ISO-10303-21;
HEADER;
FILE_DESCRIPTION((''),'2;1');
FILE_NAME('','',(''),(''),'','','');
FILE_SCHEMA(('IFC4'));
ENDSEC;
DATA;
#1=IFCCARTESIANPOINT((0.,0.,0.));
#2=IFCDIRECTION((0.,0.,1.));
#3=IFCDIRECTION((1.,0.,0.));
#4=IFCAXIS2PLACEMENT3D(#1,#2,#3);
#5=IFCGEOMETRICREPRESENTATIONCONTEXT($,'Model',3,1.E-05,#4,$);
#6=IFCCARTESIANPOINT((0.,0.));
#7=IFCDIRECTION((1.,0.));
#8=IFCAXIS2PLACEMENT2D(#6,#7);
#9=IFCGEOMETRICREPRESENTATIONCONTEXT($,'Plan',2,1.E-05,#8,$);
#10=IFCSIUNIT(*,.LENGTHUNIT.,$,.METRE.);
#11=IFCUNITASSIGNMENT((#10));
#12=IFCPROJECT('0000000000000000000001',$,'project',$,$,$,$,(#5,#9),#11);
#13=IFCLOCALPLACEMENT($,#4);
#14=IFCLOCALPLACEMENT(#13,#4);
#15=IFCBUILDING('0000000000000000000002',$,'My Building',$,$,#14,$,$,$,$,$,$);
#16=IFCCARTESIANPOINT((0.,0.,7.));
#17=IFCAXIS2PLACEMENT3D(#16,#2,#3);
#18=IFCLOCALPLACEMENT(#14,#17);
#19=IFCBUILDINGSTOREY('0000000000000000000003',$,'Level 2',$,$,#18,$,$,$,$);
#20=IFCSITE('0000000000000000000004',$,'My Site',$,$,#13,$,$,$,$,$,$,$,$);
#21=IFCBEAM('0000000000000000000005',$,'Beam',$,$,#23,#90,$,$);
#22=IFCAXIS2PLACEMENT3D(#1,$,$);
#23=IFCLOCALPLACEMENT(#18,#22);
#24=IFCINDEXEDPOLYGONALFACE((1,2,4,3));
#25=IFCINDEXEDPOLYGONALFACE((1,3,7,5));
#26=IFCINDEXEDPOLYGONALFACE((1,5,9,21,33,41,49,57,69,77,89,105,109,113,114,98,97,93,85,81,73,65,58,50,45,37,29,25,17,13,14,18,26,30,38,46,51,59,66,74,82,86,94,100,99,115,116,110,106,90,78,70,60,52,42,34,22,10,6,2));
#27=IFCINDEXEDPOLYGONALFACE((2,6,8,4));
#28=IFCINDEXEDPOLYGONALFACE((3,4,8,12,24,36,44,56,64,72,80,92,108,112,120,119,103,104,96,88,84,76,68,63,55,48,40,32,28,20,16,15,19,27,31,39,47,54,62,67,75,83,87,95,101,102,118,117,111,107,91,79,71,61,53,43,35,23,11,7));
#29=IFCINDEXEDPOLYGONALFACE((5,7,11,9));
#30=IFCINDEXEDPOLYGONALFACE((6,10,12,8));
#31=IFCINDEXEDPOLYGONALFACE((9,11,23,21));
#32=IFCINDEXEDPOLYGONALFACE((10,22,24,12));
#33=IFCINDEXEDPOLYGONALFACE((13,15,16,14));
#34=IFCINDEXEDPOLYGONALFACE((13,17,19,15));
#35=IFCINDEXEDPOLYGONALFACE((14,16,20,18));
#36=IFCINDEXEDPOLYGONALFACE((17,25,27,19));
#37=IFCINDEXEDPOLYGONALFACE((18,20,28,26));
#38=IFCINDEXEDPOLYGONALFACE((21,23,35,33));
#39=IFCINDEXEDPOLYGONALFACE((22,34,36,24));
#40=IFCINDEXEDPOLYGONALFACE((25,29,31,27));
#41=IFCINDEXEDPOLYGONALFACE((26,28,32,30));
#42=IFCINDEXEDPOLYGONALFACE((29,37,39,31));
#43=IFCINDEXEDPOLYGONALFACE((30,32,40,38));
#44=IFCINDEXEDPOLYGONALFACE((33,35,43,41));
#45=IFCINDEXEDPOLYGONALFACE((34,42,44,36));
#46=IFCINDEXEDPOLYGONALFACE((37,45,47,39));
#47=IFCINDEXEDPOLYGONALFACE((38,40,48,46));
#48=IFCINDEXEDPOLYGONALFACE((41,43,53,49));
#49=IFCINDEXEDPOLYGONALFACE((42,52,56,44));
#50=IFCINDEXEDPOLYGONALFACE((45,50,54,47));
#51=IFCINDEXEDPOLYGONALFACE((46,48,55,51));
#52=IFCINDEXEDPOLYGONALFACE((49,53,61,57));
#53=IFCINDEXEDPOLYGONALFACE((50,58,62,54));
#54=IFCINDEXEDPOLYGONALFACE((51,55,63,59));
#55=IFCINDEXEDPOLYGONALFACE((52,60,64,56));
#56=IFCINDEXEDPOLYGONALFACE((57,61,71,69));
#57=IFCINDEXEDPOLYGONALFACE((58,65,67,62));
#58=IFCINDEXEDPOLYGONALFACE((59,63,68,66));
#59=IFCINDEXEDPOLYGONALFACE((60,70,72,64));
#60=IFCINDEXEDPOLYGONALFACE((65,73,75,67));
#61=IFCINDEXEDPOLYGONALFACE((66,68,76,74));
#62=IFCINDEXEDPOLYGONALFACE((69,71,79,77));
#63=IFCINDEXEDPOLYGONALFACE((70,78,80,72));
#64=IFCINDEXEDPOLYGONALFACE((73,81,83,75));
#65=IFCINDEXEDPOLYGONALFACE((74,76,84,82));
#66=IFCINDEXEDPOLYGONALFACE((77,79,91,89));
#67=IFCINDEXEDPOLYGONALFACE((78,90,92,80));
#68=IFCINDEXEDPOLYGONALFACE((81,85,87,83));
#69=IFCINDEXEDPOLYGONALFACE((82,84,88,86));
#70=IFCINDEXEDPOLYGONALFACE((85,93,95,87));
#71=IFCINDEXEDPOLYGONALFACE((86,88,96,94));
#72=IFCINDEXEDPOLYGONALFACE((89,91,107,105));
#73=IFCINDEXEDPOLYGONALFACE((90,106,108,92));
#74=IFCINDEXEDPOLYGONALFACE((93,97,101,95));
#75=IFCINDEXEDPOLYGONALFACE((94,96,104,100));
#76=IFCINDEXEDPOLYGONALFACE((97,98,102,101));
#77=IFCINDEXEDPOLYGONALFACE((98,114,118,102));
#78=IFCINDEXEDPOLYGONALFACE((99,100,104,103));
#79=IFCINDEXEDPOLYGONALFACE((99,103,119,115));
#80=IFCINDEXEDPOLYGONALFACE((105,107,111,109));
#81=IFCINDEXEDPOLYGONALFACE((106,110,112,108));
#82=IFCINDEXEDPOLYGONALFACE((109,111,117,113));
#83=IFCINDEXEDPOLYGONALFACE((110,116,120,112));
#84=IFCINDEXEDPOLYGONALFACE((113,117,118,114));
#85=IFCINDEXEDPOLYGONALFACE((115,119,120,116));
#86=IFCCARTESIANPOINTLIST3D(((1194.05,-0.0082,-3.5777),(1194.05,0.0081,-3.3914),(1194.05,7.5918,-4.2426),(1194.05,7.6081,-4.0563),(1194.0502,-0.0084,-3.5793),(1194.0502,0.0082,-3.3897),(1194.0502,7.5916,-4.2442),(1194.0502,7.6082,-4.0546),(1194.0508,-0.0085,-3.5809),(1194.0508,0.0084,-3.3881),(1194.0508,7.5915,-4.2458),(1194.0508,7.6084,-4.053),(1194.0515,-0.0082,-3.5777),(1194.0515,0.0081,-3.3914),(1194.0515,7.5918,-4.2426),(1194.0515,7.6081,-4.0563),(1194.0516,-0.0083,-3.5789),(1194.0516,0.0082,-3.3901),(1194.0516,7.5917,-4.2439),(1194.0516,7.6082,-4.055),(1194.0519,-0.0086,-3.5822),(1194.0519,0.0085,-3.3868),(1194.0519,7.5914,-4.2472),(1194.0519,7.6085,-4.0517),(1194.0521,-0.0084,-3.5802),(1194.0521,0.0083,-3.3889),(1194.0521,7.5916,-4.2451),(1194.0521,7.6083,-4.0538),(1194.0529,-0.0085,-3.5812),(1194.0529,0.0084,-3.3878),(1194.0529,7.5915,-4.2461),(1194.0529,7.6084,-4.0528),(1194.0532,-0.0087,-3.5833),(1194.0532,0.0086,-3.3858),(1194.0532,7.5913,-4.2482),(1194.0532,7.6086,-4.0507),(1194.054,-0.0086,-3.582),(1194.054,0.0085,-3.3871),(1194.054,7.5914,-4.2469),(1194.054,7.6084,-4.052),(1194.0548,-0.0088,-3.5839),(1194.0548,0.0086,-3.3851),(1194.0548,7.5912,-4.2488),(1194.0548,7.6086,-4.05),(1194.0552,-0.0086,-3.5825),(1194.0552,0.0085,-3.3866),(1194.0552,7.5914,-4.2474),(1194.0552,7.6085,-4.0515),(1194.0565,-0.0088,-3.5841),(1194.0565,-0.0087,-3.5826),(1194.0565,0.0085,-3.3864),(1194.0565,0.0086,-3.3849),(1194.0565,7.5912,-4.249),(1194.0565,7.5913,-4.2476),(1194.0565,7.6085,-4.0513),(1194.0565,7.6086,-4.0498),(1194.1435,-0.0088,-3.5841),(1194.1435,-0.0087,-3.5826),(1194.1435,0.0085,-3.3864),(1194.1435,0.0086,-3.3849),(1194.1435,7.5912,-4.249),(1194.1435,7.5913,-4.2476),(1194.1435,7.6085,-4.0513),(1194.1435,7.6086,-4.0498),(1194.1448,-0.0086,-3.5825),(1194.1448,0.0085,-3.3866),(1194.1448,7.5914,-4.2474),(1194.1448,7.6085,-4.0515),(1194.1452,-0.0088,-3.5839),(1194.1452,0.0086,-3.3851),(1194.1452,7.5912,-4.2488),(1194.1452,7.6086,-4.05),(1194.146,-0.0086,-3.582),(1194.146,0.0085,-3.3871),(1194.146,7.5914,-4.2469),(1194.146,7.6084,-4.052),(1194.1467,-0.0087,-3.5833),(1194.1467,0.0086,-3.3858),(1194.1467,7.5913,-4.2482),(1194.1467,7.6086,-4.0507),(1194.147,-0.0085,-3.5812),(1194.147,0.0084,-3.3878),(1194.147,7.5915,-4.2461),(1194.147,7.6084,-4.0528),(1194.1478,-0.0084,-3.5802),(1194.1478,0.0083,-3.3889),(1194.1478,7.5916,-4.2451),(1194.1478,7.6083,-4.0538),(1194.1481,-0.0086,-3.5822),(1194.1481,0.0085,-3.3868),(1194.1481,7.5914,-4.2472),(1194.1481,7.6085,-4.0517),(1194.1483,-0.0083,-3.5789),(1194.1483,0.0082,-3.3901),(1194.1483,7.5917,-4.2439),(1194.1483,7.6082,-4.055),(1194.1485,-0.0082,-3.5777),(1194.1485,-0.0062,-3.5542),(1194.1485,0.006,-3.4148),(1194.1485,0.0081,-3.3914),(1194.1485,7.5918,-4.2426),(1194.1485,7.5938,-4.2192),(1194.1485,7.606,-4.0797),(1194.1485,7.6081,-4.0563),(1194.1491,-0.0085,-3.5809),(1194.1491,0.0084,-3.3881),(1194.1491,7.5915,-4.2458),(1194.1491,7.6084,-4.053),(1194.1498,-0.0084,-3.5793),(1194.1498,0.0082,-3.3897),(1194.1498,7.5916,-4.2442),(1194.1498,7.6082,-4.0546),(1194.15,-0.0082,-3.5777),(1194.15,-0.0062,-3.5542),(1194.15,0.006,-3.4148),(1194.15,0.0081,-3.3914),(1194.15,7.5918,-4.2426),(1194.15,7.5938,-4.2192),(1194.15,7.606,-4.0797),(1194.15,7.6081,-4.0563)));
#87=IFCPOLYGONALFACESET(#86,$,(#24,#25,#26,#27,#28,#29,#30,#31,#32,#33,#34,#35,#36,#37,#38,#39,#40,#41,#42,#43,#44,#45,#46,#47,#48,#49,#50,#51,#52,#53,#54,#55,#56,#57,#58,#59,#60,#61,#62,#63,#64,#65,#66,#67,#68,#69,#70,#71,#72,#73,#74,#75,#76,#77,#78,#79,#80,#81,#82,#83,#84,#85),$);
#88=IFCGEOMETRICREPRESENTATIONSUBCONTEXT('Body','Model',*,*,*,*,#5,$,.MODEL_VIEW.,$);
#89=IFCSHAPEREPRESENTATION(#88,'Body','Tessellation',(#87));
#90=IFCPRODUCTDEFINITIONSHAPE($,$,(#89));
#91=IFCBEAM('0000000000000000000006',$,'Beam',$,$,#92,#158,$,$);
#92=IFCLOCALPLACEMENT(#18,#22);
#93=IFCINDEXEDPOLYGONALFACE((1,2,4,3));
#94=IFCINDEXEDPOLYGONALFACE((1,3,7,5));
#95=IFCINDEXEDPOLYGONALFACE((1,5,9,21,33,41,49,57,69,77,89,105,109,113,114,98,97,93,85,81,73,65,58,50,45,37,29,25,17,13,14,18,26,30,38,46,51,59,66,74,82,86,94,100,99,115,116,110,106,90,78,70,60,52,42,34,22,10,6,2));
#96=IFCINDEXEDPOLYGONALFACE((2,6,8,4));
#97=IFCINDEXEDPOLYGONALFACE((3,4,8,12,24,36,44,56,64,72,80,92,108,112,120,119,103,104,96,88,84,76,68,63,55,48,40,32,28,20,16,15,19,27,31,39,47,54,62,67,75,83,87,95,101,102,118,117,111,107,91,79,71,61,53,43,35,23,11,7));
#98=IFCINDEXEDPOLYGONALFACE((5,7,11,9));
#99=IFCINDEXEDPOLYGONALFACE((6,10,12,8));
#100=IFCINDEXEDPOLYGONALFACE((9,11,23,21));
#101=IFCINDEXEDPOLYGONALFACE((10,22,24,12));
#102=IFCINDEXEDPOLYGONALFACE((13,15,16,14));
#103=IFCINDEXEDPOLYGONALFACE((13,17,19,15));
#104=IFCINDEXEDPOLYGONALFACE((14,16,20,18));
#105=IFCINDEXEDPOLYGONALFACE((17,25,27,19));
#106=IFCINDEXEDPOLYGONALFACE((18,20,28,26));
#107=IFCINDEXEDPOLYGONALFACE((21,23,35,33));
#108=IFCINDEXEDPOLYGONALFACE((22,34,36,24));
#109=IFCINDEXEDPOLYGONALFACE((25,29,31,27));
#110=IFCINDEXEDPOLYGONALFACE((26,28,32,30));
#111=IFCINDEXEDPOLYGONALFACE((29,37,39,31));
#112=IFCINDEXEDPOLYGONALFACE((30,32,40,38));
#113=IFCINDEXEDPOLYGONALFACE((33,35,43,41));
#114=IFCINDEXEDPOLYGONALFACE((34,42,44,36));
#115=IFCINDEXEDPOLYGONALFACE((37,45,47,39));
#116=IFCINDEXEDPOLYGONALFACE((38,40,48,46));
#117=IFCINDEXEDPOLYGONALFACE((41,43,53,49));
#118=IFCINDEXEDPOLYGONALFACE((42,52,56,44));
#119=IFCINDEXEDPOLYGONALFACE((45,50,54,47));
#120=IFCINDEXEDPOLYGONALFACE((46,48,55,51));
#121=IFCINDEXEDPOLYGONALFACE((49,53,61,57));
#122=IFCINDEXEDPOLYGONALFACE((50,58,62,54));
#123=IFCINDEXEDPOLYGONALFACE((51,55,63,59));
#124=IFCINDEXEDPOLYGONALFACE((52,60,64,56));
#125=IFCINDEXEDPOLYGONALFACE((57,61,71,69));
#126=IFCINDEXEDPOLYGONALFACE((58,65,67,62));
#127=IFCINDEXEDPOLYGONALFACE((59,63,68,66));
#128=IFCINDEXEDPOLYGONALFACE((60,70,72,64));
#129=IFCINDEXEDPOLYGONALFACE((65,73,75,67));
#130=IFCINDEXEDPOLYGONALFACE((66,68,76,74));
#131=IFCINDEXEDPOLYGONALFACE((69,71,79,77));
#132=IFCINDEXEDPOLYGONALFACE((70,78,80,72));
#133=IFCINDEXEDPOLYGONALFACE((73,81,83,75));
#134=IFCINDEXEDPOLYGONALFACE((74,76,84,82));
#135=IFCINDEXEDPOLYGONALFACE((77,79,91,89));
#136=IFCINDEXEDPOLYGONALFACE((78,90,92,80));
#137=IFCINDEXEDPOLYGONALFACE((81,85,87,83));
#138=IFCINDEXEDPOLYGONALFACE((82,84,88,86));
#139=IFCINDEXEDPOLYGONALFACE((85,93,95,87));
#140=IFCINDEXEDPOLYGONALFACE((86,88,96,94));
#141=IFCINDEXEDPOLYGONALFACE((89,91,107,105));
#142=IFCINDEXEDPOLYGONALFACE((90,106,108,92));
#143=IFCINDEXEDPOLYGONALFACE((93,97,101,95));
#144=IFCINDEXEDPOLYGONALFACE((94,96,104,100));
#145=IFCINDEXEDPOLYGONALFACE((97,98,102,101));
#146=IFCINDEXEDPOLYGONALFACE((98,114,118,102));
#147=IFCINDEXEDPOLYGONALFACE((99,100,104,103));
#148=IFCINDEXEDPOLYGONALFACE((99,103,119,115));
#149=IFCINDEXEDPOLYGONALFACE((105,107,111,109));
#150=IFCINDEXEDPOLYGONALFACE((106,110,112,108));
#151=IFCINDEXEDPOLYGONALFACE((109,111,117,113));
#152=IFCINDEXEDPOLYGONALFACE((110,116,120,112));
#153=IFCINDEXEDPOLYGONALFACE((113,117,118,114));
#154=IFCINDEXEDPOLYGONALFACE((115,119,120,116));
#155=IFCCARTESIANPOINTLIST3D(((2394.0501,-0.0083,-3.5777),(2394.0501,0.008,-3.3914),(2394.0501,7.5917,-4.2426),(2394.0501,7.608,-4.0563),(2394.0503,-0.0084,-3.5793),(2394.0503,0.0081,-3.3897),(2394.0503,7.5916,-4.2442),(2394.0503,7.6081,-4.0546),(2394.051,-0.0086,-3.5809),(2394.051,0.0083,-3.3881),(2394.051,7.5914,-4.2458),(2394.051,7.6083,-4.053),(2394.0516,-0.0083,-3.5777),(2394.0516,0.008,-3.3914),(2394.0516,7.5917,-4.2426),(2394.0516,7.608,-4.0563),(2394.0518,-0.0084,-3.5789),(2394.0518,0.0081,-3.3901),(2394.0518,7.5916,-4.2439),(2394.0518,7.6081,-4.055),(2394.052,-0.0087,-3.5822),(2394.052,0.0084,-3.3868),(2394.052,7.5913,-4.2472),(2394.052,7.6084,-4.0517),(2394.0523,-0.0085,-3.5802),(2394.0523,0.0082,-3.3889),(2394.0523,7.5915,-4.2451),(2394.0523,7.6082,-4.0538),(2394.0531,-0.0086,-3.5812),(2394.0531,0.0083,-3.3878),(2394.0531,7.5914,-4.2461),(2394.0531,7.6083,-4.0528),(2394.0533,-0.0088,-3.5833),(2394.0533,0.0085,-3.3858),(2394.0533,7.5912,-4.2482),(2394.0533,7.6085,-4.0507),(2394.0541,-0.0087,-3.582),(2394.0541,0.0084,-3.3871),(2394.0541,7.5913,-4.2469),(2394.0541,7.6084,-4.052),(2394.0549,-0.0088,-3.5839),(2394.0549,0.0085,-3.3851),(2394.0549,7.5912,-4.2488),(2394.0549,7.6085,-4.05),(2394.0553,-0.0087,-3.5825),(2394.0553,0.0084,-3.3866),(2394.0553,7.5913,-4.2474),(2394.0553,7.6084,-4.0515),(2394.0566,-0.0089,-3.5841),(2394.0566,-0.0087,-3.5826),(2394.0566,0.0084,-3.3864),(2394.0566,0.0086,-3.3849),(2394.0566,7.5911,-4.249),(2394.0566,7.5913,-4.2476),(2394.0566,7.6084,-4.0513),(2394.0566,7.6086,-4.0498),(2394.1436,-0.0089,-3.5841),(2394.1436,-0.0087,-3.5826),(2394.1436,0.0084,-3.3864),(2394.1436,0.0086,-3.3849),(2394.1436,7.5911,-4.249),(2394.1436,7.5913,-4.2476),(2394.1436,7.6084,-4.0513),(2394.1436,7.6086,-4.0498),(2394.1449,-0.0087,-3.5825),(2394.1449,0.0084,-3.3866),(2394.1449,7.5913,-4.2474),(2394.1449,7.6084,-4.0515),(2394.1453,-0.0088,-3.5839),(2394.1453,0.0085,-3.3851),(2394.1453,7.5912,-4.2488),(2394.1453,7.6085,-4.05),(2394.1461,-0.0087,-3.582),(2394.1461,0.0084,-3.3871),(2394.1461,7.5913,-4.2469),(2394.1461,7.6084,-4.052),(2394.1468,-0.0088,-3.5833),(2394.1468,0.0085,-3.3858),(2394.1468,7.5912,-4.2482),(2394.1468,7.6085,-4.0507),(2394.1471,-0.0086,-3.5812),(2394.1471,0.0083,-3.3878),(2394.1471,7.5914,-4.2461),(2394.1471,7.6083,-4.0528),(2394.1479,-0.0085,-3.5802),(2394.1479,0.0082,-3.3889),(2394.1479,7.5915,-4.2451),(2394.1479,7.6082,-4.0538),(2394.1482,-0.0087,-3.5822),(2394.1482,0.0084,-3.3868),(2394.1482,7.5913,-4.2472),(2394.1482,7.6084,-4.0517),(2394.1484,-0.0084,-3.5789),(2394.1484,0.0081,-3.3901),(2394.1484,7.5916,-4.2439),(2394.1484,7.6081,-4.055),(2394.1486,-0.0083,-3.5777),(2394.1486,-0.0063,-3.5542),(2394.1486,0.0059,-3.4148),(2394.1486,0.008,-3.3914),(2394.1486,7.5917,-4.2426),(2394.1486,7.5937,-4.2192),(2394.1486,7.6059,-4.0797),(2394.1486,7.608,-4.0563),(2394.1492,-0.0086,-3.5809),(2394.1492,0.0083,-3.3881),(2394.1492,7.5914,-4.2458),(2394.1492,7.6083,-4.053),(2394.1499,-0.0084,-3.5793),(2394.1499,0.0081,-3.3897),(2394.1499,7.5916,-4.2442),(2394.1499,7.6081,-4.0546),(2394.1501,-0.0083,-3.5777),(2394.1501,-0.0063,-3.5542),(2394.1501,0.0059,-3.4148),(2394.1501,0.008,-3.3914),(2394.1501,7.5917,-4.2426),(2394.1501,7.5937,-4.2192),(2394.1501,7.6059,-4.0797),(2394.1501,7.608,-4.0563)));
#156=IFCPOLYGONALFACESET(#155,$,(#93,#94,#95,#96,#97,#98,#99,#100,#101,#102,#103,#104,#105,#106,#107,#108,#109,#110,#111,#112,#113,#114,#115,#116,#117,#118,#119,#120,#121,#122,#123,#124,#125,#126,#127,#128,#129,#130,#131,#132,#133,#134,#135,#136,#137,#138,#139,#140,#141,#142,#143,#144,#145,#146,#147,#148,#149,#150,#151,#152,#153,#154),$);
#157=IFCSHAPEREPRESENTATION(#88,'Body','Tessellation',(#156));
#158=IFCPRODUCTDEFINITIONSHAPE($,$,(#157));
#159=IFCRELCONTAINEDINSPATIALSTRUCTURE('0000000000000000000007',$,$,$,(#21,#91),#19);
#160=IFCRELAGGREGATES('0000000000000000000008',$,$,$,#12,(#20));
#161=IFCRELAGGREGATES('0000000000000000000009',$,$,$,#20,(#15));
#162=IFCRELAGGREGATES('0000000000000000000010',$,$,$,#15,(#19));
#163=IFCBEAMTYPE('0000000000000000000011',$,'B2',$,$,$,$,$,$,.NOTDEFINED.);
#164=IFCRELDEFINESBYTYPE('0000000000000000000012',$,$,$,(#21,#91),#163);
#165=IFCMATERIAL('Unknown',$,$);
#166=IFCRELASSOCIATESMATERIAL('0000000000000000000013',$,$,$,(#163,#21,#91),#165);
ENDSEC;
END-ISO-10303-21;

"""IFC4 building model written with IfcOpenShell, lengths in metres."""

from ifc_helpers import new_model, si_unit, frame, origin_with_axes, origin_2d_with_axis, place, context, subcontext, project, spatial, c_section, extrude, material, material_profile, profile_set, profile_usage, type_object, element, save


model = new_model("IFC4")

# Units and contexts
model_context = context("Model", 3, precision=1e-05, world=origin_with_axes())
plan_context = context("Plan", 2, precision=1e-05, world=origin_2d_with_axis())
body_context = subcontext(model_context, "Body", "Model", "MODEL_VIEW")
ifc_project = project(units=[si_unit("LENGTHUNIT", "METRE")], contexts=[model_context, plan_context])

# Site, building, storey
site_placement = place(None, origin_with_axes())
site = spatial("IfcSite", under=ifc_project, at=site_placement, Name="My Site")
building_placement = place(site_placement, origin_with_axes())
building = spatial("IfcBuilding", under=site, at=building_placement, Name="My Building")
storey_placement = place(building_placement, frame((0.0, 0.0, 7.0), z_axis=(0.0, 0.0, 1.0), x_axis=(1.0, 0.0, 0.0)))
storey = spatial("IfcBuildingStorey", under=building, at=storey_placement, Name="Level 2")

# Shared definitions
ifc_material = material(Name="Unknown")

# Beams
ifc_material_profile_1 = material_profile(ifc_material, c_section(Depth=0.2, Width=0.1, WallThickness=0.0015, Girth=0.03, InternalFilletRadius=0.005))
ifc_profile_set_1 = profile_set([ifc_material_profile_1])
beam_type_1 = type_object("IfcBeamType", Name="B2", PredefinedType="NOTDEFINED", material=ifc_profile_set_1)
ifc_profile_usage_1 = profile_usage(ifc_profile_set_1, cardinal=5)
beam_1_placement = place(storey_placement, frame((1194.1, 7.5999, -4.1494), z_axis=(0.0, -0.996195, 0.087156), x_axis=(1.0, 0.0, 0.0)))
element("IfcBeam", 1, at=beam_1_placement, inside=storey, type_object=beam_type_1, material=ifc_profile_usage_1, Name="Beam", context=body_context, shape_type="SweptSolid", body=[
    extrude(c_section(Depth=0.2, Width=0.1, WallThickness=0.0015, Girth=0.03, InternalFilletRadius=0.005), origin_with_axes(), (0.0, 0.0, 1.0), 7.629),
])
ifc_profile_usage_2 = profile_usage(ifc_profile_set_1, cardinal=5)
beam_2_placement = place(storey_placement, frame((2394.1001, 7.5998, -4.1494), z_axis=(0.0, -0.996195, 0.087156), x_axis=(1.0, 0.0, 0.0)))
element("IfcBeam", 2, at=beam_2_placement, inside=storey, type_object=beam_type_1, material=ifc_profile_usage_2, Name="Beam", context=body_context, shape_type="SweptSolid", body=[
    extrude(c_section(Depth=0.2, Width=0.1, WallThickness=0.0015, Girth=0.03, InternalFilletRadius=0.005), origin_with_axes(), (0.0, 0.0, 1.0), 7.629),
])

save(model, "model.ifc")
